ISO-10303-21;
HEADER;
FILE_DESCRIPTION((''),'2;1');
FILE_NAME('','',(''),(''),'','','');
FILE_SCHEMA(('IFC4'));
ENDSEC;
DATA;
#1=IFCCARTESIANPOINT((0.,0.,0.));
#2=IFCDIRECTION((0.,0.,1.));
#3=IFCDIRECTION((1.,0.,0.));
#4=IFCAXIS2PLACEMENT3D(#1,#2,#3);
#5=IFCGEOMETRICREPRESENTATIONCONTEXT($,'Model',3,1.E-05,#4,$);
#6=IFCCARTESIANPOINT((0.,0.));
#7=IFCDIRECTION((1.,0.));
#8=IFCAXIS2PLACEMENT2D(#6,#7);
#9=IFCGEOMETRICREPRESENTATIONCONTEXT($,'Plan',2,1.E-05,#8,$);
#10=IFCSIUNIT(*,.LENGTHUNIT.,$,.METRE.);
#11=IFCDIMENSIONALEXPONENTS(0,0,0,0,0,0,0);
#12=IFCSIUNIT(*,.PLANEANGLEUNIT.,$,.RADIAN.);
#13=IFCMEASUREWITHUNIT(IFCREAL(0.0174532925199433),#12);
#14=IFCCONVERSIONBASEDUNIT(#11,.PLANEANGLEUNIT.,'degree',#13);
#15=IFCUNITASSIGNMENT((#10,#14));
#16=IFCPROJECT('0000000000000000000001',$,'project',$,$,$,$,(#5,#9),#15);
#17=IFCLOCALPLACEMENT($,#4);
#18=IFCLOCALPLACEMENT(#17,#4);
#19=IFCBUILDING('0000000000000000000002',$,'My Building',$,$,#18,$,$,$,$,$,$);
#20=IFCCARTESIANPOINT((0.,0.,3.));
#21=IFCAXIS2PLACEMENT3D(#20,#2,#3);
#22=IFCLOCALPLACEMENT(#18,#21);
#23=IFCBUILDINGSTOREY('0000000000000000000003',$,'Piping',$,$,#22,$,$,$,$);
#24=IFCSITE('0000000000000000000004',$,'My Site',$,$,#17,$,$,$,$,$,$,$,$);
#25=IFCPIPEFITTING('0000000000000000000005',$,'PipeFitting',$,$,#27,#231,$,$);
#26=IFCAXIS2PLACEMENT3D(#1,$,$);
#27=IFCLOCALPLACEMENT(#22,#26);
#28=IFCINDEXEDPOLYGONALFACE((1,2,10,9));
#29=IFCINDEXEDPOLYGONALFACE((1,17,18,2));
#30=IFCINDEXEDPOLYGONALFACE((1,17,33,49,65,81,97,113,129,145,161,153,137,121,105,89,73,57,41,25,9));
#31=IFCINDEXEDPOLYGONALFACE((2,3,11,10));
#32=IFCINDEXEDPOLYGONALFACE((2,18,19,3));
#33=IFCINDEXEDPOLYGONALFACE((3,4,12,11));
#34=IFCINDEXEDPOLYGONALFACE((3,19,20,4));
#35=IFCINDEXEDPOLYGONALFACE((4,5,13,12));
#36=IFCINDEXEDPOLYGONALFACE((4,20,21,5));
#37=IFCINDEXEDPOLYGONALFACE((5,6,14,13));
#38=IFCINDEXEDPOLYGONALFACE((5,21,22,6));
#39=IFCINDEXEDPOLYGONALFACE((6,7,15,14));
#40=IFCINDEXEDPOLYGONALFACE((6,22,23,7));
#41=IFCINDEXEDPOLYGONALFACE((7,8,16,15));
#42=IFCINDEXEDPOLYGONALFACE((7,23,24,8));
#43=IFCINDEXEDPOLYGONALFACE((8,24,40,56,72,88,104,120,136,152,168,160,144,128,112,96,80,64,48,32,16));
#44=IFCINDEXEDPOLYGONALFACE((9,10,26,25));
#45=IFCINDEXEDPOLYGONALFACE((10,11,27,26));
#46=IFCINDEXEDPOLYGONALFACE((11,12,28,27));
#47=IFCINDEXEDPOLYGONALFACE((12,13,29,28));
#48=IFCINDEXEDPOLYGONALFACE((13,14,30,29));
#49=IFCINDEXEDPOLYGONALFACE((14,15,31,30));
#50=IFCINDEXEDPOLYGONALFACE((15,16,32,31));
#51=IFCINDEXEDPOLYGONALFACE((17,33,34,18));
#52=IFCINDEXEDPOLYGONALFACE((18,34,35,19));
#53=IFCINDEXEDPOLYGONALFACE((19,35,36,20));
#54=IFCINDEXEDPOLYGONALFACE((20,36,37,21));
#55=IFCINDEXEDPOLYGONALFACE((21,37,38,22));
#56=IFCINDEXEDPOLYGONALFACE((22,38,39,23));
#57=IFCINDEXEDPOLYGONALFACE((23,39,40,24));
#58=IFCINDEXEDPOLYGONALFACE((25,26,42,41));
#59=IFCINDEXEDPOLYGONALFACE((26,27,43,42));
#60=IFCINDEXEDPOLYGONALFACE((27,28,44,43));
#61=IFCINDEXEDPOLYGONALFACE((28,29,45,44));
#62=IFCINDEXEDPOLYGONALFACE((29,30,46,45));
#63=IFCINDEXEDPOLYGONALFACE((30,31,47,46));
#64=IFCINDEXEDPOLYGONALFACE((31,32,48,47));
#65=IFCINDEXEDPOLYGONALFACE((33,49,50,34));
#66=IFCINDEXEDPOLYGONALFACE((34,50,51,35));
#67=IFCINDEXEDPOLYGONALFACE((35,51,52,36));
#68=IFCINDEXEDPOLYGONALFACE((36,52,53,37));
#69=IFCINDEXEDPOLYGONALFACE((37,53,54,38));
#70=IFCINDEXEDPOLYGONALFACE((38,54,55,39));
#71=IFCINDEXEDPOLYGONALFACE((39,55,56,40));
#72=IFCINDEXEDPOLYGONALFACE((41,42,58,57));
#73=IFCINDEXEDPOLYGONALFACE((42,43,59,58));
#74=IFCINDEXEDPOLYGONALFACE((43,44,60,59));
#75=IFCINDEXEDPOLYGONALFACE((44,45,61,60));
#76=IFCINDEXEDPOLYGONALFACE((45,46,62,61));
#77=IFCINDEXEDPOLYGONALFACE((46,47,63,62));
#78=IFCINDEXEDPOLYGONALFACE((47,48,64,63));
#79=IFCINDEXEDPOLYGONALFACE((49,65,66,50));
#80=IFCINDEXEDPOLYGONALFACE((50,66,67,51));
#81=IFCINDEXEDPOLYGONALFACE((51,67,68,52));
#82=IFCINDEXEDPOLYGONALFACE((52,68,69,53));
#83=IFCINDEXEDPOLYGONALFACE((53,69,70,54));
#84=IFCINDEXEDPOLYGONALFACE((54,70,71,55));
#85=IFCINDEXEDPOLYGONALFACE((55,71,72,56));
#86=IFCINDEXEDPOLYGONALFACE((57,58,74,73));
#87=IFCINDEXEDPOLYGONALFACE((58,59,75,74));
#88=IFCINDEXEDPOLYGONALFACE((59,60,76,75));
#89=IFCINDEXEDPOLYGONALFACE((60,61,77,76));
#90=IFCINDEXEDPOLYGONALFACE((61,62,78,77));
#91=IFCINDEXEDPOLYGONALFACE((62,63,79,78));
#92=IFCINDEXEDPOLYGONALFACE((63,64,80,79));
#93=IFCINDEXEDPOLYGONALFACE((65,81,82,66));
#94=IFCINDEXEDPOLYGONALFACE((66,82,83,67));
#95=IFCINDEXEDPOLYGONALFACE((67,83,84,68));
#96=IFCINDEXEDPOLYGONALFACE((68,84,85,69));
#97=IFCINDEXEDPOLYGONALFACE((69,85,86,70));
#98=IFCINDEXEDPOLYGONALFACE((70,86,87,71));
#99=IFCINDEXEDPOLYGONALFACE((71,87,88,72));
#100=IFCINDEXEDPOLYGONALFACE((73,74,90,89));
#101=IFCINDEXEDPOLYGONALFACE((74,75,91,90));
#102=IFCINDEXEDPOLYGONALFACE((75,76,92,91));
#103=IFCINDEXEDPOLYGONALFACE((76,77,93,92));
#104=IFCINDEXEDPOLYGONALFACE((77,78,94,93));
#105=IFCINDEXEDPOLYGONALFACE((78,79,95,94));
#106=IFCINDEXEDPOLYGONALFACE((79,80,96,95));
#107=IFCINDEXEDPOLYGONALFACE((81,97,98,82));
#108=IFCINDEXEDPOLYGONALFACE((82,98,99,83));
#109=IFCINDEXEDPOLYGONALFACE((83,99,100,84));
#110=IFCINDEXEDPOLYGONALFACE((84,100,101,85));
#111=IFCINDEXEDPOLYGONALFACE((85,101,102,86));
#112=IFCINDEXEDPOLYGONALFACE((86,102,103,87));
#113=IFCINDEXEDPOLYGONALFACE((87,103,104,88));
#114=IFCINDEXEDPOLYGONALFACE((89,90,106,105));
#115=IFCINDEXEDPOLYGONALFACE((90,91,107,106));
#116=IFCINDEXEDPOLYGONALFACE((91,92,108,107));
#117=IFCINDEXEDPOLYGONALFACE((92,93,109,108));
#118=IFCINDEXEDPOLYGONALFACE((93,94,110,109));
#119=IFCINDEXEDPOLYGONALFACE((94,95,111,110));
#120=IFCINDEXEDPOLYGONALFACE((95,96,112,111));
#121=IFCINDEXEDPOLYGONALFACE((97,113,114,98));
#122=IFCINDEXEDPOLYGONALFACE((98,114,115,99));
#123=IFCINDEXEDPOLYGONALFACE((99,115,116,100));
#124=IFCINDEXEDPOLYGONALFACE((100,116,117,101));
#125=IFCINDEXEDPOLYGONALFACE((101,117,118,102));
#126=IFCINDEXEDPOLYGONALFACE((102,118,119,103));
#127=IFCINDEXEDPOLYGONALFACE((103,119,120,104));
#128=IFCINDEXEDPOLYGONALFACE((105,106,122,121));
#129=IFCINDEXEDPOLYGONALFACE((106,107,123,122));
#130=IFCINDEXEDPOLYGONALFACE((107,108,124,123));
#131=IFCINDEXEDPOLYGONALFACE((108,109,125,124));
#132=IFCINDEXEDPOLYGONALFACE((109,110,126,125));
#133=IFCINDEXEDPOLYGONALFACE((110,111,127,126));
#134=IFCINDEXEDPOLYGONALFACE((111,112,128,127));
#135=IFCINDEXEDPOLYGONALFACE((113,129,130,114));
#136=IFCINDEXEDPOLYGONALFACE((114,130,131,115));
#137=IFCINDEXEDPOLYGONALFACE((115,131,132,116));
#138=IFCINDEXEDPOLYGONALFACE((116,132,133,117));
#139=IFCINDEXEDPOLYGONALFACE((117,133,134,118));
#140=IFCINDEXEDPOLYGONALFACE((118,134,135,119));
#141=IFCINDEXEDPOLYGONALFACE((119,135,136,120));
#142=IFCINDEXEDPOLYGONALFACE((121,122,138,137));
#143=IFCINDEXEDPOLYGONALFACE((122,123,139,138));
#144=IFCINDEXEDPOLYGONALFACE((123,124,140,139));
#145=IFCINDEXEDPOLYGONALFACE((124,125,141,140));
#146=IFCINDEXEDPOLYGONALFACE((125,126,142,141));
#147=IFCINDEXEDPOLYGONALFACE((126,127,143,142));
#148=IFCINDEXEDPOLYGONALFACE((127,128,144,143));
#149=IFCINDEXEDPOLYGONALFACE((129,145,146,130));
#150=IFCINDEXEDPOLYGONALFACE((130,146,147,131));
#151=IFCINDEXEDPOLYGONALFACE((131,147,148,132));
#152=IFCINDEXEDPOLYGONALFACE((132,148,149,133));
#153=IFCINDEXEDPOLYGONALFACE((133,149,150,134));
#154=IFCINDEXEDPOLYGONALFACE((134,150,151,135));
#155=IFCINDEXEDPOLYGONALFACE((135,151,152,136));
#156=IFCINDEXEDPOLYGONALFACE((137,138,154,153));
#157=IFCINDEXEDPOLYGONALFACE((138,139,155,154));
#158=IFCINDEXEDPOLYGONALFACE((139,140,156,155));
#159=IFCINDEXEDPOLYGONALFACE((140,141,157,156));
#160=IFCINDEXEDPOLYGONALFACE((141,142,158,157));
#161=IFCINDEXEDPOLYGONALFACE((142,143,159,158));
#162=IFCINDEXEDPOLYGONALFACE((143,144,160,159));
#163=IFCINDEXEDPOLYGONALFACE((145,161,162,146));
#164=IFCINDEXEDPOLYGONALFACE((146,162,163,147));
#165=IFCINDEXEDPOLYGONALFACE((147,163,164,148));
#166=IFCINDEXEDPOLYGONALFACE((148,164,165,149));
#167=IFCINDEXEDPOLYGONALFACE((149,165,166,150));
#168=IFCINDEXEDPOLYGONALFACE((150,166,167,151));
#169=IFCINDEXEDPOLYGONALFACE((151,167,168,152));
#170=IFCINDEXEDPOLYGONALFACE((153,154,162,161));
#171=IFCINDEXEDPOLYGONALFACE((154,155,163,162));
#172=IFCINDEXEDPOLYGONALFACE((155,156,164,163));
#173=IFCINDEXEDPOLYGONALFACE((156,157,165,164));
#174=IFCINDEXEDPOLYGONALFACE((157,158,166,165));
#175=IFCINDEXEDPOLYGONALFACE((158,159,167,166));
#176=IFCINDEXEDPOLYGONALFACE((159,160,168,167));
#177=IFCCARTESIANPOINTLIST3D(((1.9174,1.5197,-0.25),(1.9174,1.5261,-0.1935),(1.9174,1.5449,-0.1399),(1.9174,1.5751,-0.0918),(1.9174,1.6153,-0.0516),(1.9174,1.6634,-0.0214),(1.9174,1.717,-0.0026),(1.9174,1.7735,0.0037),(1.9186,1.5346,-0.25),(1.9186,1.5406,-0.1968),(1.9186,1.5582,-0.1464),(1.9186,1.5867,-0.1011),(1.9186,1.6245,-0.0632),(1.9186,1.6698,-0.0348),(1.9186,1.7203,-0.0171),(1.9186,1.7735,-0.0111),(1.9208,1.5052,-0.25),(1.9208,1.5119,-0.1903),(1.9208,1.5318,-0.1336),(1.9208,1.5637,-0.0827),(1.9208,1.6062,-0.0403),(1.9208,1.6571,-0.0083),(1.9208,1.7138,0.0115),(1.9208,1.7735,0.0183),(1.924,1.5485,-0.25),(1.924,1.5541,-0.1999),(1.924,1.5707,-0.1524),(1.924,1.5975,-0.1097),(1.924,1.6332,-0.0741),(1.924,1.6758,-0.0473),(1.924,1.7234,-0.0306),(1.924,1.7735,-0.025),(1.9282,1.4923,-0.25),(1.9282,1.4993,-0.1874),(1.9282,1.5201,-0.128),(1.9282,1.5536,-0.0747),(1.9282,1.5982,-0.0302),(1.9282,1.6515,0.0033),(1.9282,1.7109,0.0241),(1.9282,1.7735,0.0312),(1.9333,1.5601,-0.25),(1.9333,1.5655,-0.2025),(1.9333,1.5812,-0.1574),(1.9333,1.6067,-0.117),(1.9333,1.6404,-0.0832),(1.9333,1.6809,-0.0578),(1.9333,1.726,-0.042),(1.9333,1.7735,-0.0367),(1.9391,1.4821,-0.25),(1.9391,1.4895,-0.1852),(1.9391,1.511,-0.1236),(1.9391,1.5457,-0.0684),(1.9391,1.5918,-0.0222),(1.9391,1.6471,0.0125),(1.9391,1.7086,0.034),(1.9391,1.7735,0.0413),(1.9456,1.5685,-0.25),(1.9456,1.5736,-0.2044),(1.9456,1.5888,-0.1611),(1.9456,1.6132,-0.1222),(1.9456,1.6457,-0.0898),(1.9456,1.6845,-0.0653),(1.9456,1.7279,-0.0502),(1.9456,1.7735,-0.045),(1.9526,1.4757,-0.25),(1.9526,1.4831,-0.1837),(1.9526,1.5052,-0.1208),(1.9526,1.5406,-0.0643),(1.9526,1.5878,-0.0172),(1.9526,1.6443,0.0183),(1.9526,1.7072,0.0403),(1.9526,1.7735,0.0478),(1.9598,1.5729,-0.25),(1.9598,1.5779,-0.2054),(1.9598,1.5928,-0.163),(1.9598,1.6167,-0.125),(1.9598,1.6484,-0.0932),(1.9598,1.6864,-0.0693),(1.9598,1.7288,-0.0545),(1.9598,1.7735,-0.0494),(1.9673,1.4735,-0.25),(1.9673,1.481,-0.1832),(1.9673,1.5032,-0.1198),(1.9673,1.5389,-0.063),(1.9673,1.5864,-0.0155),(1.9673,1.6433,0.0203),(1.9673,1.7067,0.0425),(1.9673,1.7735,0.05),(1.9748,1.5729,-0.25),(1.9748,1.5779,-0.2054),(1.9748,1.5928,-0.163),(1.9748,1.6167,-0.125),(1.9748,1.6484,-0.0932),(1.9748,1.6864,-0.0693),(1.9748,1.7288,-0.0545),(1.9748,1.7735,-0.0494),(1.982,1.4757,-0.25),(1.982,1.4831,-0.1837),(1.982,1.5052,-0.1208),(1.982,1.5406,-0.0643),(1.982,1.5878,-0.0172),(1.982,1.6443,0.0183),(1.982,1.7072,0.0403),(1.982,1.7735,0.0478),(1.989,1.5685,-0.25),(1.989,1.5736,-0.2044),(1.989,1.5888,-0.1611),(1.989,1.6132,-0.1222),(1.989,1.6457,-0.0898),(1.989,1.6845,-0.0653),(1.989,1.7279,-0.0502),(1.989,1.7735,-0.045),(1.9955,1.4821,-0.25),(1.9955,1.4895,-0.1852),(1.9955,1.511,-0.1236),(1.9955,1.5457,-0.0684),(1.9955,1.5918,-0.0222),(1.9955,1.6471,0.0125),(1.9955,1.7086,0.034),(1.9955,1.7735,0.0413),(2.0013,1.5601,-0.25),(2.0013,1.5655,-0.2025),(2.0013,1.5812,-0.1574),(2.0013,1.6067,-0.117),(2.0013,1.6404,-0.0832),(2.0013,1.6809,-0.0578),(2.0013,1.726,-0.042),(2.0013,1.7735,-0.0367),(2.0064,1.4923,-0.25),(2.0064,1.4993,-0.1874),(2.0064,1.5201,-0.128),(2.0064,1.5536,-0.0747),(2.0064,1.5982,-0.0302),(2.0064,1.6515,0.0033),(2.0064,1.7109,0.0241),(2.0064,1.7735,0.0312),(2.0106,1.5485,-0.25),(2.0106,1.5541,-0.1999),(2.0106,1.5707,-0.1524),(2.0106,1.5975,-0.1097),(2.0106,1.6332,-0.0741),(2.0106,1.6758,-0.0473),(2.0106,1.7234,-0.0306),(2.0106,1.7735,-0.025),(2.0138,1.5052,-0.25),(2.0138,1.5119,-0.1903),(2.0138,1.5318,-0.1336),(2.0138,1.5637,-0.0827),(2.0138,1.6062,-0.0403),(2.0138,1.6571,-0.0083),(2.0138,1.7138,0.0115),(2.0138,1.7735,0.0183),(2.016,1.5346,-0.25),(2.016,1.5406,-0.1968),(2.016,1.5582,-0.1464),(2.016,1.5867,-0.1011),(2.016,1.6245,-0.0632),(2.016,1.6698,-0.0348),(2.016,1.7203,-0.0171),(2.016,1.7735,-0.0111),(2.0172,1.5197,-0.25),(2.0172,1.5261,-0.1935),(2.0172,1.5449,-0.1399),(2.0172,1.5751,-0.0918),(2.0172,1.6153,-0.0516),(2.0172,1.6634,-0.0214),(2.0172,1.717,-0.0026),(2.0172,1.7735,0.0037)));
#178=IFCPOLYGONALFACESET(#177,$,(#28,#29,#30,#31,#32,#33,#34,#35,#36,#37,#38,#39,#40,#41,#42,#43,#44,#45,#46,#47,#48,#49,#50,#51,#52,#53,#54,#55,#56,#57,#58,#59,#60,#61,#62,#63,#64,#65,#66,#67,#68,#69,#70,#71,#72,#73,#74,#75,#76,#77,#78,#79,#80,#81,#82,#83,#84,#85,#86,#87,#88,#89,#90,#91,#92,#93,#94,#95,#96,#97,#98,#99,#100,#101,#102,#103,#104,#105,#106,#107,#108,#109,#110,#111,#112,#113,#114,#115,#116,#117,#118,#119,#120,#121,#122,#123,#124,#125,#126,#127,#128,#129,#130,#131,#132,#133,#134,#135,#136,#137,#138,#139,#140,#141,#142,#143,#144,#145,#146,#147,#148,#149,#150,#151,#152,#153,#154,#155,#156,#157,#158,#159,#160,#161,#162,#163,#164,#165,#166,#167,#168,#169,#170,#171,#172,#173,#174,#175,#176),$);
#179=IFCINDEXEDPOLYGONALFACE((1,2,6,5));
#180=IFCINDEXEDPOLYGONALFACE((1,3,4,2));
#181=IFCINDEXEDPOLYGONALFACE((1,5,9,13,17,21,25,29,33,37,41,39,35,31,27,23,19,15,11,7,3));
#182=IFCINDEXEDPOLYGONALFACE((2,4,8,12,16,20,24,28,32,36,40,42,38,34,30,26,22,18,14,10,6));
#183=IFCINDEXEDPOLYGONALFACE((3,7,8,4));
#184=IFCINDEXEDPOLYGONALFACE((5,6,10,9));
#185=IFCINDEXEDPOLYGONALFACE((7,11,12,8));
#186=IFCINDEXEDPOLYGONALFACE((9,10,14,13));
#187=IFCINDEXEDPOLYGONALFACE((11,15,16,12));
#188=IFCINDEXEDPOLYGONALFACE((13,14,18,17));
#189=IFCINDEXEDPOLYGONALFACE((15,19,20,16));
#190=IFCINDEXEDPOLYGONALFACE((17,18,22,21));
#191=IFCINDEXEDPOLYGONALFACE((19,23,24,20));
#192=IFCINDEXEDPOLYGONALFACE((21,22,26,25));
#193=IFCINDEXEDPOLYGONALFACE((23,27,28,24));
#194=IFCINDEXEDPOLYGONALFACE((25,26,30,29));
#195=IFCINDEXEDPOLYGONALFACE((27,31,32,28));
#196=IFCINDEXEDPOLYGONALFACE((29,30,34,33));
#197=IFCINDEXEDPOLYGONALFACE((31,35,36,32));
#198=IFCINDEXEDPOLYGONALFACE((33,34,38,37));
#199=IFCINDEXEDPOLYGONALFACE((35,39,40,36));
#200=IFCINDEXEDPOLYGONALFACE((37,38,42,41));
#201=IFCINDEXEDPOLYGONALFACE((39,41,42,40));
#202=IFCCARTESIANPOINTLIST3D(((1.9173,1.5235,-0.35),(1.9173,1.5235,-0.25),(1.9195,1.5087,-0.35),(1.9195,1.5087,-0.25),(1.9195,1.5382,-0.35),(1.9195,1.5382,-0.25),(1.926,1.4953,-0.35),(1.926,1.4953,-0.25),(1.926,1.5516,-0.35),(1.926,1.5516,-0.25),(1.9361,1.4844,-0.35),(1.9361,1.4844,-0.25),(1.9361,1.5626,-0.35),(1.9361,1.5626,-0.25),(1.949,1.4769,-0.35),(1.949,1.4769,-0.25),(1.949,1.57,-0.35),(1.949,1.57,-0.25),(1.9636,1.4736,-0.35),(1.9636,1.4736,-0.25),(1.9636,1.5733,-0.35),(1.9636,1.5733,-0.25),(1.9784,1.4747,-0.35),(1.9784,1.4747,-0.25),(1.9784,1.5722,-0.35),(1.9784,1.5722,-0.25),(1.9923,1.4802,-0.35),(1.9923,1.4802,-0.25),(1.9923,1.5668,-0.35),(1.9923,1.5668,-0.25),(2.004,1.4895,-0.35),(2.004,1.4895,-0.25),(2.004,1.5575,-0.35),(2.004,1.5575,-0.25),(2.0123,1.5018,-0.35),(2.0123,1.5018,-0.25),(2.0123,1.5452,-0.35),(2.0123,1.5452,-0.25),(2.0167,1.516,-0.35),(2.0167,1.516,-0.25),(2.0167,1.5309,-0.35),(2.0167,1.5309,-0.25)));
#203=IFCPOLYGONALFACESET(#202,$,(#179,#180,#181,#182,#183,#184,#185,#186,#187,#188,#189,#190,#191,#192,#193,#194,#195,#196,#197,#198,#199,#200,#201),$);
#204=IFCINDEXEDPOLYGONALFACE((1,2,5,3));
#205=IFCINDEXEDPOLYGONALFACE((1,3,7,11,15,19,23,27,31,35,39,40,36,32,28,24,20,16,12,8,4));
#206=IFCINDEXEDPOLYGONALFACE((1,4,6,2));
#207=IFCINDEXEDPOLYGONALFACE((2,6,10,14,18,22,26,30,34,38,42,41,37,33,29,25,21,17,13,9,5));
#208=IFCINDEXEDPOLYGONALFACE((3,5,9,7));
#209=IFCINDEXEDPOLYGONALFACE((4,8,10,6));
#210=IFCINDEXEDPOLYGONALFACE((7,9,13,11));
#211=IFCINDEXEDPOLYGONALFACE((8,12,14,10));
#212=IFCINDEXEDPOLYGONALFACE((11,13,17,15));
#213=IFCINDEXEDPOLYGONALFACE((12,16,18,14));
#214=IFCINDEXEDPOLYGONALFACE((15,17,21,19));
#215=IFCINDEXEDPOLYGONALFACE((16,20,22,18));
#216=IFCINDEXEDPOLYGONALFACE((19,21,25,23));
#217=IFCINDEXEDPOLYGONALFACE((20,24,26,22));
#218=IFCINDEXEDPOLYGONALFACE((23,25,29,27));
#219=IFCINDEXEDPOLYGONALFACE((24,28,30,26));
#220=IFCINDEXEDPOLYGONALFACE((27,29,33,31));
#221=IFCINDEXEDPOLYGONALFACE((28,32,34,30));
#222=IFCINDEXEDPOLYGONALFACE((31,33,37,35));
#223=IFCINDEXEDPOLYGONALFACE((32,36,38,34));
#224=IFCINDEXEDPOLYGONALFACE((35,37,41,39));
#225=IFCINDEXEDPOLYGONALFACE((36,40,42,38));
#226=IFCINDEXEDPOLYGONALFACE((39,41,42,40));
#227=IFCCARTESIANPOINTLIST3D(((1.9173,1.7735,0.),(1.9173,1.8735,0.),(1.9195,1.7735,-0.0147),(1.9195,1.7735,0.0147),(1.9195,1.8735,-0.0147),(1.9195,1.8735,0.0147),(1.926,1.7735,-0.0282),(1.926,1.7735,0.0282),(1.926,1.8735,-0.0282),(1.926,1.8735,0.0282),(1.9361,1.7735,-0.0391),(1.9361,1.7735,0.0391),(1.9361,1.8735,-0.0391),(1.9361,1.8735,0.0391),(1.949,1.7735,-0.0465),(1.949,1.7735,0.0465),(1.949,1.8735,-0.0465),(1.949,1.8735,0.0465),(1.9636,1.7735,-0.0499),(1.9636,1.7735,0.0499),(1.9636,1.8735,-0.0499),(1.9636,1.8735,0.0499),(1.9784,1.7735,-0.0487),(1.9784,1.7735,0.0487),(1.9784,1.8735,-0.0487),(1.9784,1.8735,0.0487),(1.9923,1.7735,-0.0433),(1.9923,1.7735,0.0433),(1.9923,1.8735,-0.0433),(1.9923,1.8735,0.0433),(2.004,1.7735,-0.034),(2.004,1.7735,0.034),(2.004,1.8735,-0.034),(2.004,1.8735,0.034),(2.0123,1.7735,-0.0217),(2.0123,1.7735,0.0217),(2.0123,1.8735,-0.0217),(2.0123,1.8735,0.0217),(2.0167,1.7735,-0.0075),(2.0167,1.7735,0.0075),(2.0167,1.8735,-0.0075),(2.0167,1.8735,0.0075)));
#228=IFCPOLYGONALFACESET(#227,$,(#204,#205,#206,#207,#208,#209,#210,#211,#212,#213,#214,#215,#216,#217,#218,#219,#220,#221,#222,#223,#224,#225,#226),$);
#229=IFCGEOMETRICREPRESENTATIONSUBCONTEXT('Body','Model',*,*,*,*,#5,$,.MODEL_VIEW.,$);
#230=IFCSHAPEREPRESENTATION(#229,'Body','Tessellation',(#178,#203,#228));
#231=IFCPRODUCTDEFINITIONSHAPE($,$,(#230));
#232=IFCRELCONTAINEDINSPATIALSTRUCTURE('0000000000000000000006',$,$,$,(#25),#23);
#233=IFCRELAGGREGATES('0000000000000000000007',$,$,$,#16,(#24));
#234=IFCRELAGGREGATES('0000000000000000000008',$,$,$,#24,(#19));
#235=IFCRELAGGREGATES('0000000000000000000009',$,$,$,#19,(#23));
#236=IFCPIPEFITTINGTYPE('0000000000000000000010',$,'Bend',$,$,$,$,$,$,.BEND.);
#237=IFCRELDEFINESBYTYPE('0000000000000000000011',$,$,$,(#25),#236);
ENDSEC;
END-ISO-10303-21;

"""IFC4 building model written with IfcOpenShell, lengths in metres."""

from ifc_helpers import new_model, entity, si_unit, converted_unit, frame, origin_with_axes, origin_2d_with_axis, place, context, subcontext, project, spatial, line, indexed_curve, circle, outline, extrude, source, transform, mapped, type_object, type_shapes, element, save


model = new_model("IFC4")

# Units and contexts
model_context = context("Model", 3, precision=1e-05, world=origin_with_axes())
plan_context = context("Plan", 2, precision=1e-05, world=origin_2d_with_axis())
body_context = subcontext(model_context, "Body", "Model", "MODEL_VIEW")
ifc_project = project(units=[si_unit("LENGTHUNIT", "METRE"), converted_unit("PLANEANGLEUNIT", "degree", entity("IfcReal", 0.0174532925199433), si_unit("PLANEANGLEUNIT", "RADIAN"), dimensions=[0, 0, 0, 0, 0, 0, 0])], contexts=[model_context, plan_context])

# Site, building, storey
site_placement = place(None, origin_with_axes())
site = spatial("IfcSite", under=ifc_project, at=site_placement, Name="My Site")
building_placement = place(site_placement, origin_with_axes())
building = spatial("IfcBuilding", under=site, at=building_placement, Name="My Building")
storey_placement = place(building_placement, frame((0.0, 0.0, 3.0), z_axis=(0.0, 0.0, 1.0), x_axis=(1.0, 0.0, 0.0)))
storey = spatial("IfcBuildingStorey", under=building, at=storey_placement, Name="Piping")

# Pipe fitting, opening
pipe_fitting_type = type_object("IfcPipeFittingType", Name="Bend", PredefinedType="BEND")
shared_shape = source(origin_with_axes(), body_context, "Body", "SolidModel", [
    entity("IfcSweptDiskSolid", entity("IfcIndexedPolyCurve", entity("IfcCartesianPointList3D", [[0.0, 0.0, -0.1], [0.0, 0.0732, -0.2768], [0.0, 0.25, -0.35]]), [entity("IfcArcIndex", [1, 2, 3])]), 0.05),
    extrude(circle(Radius=0.05), origin_with_axes(), (0.0, 0.0, -1.0), 0.1),
    extrude(circle(Radius=0.05), frame((0.0, 0.25, -0.35), z_axis=(0.0, 1.0, 0.0), x_axis=(1.0, 0.0, 0.0)), (0.0, 0.0, 1.0), 0.1),
])
type_shapes(pipe_fitting_type, [shared_shape])
pipe_fitting_1_placement = place(storey_placement, frame((1.9673, 1.5235, -0.35), z_axis=(0.0, 0.0, -1.0), x_axis=(-1.0, 0.0, 0.0)))
pipe_fitting_1 = element("IfcPipeFitting", 1, at=pipe_fitting_1_placement, inside=storey, type_object=pipe_fitting_type, Name="PipeFitting", context=body_context, shape_type="MappedRepresentation", body=[
    mapped(shared_shape, transform((0.0, 0.0, 0.0), x_axis=(1.0, 0.0, 0.0), y_axis=(0.0, 1.0, 0.0), z_axis=(0.0, 0.0, 1.0), scale=1.0)),
])
opening_1_placement = place(pipe_fitting_1_placement, frame((1.9673, -1.5235, 2.65), z_axis=(0.0, 0.0, -1.0), x_axis=(-1.0, 0.0, 0.0)))
element("IfcOpeningElement", 2, at=opening_1_placement, cuts=pipe_fitting_1, PredefinedType="OPENING", context=body_context, shape_type="SweptSolid", body=[
    extrude(outline(indexed_curve([(0.0, 0.0), (0.5, 0.0), (0.5, 0.5), (0.0, 0.5)], segments=[line(1, 2, 3, 4, 1)])), origin_with_axes(), (0.0, 0.0, 1.0), 0.5),
])

save(model, "model.ifc")
